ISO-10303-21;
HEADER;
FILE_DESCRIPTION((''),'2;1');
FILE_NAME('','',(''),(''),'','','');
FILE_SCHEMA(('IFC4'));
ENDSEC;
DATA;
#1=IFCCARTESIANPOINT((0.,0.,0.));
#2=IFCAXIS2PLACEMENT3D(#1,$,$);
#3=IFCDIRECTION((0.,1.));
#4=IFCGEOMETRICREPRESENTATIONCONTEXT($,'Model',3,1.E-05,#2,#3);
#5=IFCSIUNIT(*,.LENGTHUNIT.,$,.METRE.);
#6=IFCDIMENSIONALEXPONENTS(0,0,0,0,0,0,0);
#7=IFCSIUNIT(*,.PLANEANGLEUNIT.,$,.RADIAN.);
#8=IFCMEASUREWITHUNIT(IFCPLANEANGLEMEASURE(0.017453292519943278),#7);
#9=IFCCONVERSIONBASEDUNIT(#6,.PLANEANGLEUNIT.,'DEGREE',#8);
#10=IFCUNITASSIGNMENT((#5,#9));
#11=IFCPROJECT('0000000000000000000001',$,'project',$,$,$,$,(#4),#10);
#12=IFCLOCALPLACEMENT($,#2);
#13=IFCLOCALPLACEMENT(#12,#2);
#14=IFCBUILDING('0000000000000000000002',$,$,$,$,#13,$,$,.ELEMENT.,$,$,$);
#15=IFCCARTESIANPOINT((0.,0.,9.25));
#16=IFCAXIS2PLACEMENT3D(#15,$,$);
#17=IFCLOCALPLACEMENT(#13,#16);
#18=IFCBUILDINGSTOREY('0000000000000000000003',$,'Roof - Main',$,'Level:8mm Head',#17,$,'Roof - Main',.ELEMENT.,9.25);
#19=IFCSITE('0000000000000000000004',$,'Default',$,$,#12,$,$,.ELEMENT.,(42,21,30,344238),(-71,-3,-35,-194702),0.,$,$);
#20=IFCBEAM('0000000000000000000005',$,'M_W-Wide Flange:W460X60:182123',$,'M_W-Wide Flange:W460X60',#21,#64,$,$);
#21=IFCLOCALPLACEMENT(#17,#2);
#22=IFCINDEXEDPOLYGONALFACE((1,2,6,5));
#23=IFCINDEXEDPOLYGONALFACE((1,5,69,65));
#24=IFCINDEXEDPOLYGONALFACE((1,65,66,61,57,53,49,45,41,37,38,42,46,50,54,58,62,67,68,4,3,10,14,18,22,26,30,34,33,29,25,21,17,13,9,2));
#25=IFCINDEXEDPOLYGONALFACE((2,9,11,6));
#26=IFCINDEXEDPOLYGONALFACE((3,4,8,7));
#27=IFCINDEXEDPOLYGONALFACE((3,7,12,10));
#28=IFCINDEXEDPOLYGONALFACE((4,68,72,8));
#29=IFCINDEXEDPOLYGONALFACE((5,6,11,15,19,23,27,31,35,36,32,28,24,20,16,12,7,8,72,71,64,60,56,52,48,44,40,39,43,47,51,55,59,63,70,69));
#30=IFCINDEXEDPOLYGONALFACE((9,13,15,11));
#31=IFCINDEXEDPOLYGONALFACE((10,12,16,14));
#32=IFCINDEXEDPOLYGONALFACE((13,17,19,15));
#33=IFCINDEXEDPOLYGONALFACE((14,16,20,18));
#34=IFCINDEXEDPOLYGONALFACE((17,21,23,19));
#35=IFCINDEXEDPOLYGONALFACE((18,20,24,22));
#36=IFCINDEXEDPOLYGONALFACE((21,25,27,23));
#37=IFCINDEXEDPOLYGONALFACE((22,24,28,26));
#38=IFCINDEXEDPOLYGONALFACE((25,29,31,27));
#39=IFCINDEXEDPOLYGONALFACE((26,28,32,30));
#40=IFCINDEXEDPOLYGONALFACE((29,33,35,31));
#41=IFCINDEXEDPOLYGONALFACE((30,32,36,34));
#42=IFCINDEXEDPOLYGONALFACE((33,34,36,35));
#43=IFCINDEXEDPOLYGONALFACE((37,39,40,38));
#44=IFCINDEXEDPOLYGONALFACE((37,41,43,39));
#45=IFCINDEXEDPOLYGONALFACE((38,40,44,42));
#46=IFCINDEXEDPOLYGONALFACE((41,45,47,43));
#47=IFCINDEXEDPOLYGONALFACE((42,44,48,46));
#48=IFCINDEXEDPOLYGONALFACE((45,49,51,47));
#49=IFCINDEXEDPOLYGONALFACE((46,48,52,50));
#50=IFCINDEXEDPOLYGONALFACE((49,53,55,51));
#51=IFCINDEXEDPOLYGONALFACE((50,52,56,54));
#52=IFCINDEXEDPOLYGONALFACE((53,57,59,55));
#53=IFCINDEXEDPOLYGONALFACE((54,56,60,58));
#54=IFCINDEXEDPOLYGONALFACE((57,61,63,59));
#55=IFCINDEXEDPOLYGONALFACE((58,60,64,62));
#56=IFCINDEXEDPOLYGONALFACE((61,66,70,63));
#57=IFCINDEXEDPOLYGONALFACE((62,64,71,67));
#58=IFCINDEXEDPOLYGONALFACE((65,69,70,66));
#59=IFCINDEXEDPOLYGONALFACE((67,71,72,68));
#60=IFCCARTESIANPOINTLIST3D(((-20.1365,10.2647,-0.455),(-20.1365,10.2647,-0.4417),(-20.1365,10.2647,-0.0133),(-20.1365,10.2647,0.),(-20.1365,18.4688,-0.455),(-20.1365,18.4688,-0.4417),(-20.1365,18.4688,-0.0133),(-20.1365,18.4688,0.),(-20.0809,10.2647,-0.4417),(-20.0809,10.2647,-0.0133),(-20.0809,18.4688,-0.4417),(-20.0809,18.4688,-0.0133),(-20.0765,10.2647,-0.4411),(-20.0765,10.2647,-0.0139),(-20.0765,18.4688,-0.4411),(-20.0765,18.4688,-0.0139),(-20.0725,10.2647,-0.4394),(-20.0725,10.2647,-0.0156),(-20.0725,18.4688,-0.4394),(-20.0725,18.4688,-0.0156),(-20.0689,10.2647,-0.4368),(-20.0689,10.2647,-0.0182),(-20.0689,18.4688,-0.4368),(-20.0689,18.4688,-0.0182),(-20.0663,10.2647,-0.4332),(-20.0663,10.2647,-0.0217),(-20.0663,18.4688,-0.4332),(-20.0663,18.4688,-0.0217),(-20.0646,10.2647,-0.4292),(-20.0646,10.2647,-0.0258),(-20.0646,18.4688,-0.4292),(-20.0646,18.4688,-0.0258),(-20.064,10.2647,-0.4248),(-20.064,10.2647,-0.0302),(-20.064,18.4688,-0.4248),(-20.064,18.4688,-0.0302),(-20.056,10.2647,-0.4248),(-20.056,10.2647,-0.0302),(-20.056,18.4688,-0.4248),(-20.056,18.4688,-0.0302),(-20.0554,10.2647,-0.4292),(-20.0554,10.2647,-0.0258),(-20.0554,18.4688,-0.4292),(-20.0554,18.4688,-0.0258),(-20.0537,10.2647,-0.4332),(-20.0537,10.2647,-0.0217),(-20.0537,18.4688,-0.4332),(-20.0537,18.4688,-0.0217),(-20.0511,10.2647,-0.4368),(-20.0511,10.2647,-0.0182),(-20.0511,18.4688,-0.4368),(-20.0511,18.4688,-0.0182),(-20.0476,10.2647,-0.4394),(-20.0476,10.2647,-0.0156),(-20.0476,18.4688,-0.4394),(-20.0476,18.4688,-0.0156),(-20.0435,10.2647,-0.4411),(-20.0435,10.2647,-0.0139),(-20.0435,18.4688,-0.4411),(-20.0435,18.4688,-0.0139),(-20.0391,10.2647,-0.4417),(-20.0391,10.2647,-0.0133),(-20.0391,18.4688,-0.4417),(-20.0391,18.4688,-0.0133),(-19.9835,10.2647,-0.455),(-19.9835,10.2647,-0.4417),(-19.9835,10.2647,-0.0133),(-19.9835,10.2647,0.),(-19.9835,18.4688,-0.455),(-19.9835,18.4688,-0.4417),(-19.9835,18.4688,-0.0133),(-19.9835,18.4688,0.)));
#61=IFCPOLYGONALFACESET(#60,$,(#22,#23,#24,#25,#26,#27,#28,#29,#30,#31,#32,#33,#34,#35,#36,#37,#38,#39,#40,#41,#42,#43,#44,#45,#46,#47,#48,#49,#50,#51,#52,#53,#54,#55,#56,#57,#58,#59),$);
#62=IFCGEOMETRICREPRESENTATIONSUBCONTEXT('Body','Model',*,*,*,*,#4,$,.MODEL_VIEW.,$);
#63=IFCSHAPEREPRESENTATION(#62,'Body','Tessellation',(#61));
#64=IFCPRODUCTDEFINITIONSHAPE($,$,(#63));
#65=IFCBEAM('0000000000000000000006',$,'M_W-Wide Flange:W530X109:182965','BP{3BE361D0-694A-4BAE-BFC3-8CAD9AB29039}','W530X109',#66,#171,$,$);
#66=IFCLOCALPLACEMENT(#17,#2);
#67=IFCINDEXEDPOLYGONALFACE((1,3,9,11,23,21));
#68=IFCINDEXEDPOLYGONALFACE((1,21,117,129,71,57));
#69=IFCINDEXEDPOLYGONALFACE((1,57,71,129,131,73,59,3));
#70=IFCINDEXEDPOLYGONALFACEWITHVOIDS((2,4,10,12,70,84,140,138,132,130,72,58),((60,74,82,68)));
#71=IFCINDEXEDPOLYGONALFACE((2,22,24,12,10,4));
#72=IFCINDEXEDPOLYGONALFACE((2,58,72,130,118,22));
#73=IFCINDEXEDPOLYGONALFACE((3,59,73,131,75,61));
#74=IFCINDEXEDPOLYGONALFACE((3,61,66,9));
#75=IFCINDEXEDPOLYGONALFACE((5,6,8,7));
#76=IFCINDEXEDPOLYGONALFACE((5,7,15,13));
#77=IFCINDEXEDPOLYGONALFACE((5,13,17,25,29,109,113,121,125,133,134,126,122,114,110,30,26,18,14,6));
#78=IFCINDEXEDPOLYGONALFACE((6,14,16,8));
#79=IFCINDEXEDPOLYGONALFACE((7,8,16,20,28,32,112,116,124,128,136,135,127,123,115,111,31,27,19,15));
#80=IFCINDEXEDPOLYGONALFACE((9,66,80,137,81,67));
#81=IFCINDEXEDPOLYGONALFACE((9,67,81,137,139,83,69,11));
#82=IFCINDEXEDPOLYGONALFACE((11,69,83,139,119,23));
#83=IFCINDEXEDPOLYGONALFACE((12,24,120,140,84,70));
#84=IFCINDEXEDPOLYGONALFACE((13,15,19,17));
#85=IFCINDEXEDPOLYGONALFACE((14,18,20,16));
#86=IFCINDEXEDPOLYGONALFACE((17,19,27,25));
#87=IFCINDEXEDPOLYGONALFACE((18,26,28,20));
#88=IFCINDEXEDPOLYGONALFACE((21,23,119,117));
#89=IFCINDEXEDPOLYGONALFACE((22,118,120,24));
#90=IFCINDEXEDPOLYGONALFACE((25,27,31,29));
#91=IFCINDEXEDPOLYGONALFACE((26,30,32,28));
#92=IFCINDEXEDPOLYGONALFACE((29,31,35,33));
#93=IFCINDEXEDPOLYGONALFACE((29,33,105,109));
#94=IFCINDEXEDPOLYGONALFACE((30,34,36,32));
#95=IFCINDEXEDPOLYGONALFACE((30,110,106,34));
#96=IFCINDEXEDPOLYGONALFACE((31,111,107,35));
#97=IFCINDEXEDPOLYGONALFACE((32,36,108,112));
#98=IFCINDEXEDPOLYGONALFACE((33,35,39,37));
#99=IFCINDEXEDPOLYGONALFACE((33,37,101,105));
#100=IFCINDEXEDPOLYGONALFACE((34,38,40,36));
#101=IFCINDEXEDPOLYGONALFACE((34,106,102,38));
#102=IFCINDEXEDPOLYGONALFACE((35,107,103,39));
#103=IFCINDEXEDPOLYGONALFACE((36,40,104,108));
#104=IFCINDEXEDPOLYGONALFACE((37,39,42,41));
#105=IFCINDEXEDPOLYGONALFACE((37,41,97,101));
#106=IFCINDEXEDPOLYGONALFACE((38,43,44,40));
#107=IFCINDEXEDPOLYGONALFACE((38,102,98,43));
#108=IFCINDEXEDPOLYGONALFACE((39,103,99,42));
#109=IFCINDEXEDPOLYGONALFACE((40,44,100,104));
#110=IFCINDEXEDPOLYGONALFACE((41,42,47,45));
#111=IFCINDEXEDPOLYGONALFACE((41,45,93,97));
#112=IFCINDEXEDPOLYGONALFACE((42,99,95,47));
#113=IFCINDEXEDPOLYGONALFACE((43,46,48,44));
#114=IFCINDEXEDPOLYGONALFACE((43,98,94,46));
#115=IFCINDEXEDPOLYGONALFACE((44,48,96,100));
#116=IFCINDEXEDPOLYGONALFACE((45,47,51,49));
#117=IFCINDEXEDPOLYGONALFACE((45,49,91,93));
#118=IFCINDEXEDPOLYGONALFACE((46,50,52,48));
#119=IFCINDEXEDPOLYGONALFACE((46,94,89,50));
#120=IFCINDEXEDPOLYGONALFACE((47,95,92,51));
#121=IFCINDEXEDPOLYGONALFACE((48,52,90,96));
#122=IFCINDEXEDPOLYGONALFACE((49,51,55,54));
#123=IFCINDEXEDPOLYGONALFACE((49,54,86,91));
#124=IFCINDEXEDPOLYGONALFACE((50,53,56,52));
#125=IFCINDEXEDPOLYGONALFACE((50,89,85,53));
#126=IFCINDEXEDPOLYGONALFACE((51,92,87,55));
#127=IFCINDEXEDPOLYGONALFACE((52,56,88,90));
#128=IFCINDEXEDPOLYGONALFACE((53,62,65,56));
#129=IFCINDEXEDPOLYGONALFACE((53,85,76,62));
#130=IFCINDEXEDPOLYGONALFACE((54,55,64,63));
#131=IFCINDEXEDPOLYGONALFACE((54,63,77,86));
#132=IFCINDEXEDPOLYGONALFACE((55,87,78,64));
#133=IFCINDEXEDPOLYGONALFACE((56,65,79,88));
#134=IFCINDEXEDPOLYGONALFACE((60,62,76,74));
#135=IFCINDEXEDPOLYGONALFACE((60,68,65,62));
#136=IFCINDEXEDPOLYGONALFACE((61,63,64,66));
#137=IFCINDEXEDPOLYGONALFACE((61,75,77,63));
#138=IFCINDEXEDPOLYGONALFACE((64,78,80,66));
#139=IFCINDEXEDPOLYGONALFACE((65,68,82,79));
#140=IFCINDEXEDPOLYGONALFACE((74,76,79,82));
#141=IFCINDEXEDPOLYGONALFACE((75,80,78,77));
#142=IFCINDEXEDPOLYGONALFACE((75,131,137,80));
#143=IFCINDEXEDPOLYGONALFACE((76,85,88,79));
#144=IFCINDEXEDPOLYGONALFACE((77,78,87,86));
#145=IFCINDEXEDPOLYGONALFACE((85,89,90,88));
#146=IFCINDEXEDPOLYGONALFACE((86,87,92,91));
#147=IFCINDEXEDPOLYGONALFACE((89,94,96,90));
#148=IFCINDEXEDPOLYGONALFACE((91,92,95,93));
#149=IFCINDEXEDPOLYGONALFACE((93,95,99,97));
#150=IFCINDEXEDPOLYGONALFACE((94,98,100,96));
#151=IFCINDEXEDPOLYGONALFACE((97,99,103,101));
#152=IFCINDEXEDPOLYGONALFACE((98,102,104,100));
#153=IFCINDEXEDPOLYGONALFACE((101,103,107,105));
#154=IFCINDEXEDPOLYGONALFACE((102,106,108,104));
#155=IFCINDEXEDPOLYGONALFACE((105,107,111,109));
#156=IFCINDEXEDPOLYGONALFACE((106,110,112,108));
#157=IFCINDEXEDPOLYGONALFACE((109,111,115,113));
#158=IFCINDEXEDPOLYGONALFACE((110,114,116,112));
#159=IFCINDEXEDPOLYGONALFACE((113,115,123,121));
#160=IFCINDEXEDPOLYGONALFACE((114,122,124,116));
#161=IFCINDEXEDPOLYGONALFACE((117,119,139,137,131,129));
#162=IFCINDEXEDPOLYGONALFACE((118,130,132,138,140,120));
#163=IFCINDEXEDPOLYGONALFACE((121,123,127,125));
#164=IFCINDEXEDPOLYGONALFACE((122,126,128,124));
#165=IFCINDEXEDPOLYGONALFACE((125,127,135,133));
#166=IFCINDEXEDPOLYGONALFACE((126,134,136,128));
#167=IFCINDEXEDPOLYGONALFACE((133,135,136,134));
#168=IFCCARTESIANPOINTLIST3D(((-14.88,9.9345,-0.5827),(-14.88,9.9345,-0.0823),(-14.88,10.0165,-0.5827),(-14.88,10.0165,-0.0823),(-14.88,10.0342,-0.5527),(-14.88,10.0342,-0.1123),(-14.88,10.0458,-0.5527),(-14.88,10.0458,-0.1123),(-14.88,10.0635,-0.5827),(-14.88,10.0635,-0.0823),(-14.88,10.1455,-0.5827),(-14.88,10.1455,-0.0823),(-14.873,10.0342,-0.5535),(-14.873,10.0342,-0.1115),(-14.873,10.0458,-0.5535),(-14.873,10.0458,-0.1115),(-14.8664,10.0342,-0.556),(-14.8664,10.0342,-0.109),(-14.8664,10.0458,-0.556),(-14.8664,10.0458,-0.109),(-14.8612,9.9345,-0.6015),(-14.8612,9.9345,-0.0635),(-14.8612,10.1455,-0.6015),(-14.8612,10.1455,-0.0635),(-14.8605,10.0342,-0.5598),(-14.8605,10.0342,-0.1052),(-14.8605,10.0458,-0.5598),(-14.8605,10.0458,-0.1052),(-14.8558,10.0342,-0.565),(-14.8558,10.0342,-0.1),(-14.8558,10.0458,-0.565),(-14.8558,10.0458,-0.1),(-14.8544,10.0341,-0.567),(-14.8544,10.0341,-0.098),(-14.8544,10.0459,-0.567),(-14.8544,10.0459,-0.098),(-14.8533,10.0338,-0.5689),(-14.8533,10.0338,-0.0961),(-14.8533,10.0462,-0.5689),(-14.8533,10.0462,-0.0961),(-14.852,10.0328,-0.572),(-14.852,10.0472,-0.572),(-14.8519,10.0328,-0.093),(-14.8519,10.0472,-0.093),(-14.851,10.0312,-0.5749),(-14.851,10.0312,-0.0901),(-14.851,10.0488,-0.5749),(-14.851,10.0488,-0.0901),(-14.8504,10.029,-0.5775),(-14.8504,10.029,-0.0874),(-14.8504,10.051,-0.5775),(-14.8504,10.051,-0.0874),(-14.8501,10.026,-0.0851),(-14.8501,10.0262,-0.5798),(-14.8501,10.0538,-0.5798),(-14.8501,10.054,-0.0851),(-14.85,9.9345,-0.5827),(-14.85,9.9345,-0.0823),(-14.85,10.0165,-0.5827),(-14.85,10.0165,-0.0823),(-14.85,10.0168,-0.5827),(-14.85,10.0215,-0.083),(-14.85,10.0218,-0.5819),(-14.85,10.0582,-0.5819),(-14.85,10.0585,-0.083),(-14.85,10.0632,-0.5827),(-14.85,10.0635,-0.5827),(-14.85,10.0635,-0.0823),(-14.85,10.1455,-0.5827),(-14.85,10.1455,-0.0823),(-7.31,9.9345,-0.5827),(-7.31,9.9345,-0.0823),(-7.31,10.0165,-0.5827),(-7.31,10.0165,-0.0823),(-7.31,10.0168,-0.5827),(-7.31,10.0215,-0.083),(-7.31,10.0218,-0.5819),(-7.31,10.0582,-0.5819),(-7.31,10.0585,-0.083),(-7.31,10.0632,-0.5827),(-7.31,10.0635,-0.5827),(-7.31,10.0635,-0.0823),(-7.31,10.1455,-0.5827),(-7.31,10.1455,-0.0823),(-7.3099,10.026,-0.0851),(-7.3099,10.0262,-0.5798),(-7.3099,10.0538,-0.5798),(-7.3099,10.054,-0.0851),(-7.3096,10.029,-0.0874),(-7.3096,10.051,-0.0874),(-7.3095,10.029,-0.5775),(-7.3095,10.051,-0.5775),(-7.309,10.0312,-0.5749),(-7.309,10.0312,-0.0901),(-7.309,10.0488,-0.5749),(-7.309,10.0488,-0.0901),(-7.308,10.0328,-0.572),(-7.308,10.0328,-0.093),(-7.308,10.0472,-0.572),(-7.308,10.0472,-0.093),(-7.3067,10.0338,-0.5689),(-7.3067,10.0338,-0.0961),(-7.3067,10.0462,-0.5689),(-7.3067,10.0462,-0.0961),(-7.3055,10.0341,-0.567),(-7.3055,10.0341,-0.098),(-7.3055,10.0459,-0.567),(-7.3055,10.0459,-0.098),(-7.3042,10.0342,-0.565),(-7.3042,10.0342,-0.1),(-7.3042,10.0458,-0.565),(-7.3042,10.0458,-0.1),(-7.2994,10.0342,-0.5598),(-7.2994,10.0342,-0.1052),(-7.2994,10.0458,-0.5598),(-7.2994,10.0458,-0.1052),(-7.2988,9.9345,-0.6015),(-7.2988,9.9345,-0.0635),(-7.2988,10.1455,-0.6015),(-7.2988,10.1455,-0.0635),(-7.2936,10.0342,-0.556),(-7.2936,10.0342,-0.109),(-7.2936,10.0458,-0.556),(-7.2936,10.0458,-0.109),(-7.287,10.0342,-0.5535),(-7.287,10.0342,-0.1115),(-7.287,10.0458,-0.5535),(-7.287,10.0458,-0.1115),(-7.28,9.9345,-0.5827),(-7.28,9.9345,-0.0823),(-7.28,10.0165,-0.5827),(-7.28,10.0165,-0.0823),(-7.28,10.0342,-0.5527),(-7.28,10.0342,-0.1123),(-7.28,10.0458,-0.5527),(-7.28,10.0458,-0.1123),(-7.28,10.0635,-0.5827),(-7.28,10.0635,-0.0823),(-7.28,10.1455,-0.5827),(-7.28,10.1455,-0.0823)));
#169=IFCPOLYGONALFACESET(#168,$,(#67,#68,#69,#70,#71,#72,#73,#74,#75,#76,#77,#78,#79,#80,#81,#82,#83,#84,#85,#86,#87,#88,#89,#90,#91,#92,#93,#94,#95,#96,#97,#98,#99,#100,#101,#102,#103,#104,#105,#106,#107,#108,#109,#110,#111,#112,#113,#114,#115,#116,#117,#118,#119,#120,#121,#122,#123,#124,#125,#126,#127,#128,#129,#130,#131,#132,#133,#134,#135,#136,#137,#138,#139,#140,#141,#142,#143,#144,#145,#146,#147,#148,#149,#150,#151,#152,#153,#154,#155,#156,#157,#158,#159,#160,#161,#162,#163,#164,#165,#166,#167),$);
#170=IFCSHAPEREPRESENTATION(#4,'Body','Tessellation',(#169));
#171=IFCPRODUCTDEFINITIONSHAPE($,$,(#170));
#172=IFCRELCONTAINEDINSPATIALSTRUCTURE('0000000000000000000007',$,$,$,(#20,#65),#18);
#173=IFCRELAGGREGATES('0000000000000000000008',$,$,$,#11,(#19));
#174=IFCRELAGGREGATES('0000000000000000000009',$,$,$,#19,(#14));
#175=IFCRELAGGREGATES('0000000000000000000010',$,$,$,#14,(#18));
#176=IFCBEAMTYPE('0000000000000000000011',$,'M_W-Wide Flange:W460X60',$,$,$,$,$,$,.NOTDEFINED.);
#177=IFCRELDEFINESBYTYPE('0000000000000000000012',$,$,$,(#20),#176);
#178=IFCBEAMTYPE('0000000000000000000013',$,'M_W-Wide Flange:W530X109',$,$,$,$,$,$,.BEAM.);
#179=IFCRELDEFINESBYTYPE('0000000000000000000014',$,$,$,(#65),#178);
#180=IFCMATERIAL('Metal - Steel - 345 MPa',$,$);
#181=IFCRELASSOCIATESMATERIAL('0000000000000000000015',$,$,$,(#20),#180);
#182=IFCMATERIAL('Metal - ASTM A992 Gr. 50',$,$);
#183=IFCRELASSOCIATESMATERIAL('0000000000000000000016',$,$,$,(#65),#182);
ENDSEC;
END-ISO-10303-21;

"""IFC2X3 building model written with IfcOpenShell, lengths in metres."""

from ifc_helpers import new_model, entity, si_unit, converted_unit, point, direction, frame, frame_2d, origin, origin_2d, place, context, subcontext, project, spatial, polyline, circle_curve, line_curve, trimmed, segment, composite_curve, i_section, outline, extrude, material, type_object, element, save


model = new_model("IFC2X3")

# Units and contexts
model_context = context("Model", 3, precision=1e-05, world=origin(), true_north=direction((0.0, 1.0)))
body_context = subcontext(model_context, "Body", "Model", "MODEL_VIEW")
ifc_project = project(units=[si_unit("LENGTHUNIT", "METRE"), converted_unit("PLANEANGLEUNIT", "DEGREE", entity("IfcPlaneAngleMeasure", 0.017453292519943278), si_unit("PLANEANGLEUNIT", "RADIAN"), dimensions=[0, 0, 0, 0, 0, 0, 0])], contexts=[model_context])

# Site, building, storey
site_placement = place(None, origin())
site = spatial("IfcSite", under=ifc_project, at=site_placement, Name="Default", CompositionType="ELEMENT", RefLatitude=(42, 21, 30, 344238), RefLongitude=(-71, -3, -35, -194702), RefElevation=0.0)
building_placement = place(site_placement, origin())
building = spatial("IfcBuilding", under=site, at=building_placement, CompositionType="ELEMENT")
storey_placement = place(building_placement, frame((0.0, 0.0, 9.25)))
storey = spatial("IfcBuildingStorey", under=building, at=storey_placement, Name="Roof - Main", ObjectType="Level:8mm Head", LongName="Roof - Main", CompositionType="ELEMENT", Elevation=9.25)

# Beam
ifc_material_1 = material(Name="Metal - Steel - 345 MPa")
beam_type_1 = type_object("IfcBeamType", Name="M_W-Wide Flange:W460X60", PredefinedType="NOTDEFINED")
beam_1_placement = place(storey_placement, frame((-20.06, 10.04, 0.0), z_axis=(0.0, 0.0, 1.0), x_axis=(0.0, 1.0, 0.0)))
element("IfcBeam", 1, at=beam_1_placement, inside=storey, type_object=beam_type_1, material=ifc_material_1, Name="M_W-Wide Flange:W460X60:182123", ObjectType="M_W-Wide Flange:W460X60", context=body_context, shape_type="SweptSolid", body=[
    extrude(i_section(OverallWidth=0.153, OverallDepth=0.455, WebThickness=0.008, FlangeThickness=0.0133, FilletRadius=0.0169, at=frame_2d((0.0, 0.0), x_axis=(0.0, 1.0))), frame((0.2247, 0.0, -0.2275), z_axis=(1.0, 0.0, 0.0), x_axis=(0.0, 0.0, -1.0)), (0.0, 0.0, 1.0), 8.2041),
])

# Beam, openings
ifc_material_2 = material(Name="Metal - ASTM A992 Gr. 50")
beam_type_2 = type_object("IfcBeamType", Name="M_W-Wide Flange:W530X109", PredefinedType="BEAM")
beam_2_placement = place(storey_placement, frame((-14.88, 10.04, -0.3325), z_axis=(-1.0, 0.0, 0.0), x_axis=(0.0, -1.0, 0.0)))
beam_2 = element("IfcBeam", 2, at=beam_2_placement, inside=storey, type_object=beam_type_2, material=ifc_material_2, Name="M_W-Wide Flange:W530X109:182965", Description="BP{3BE361D0-694A-4BAE-BFC3-8CAD9AB29039}", ObjectType="W530X109", context=model_context, shape_type="SweptSolid", body=[
    extrude(i_section(OverallWidth=0.211, OverallDepth=0.538, WebThickness=0.0116, FlangeThickness=0.0188, FilletRadius=0.0177, at=origin_2d()), origin(), (0.0, 0.0, -1.0), 7.6),
])
opening_1_placement = place(beam_2_placement, frame((0.2056, 0.269, 0.0), z_axis=(-1.0, 0.0, 0.0), x_axis=(0.0, 0.0, 1.0)))
element("IfcOpeningElement", 3, at=opening_1_placement, cuts=beam_2, ObjectType="Opening", context=model_context, shape_type="SweptSolid", body=[
    extrude(outline(polyline([(0.0, -0.0188), (0.0, 0.0), (-0.0188, 0.0), (0.0, -0.0188)])), origin(), (0.0, 0.0, 1.0), 0.4112),
])
opening_2_placement = place(beam_2_placement, frame((-0.2056, 0.269, 0.0), z_axis=(1.0, 0.0, 0.0), x_axis=(0.0, 0.0, -1.0)))
element("IfcOpeningElement", 4, at=opening_2_placement, cuts=beam_2, ObjectType="Opening", context=model_context, shape_type="SweptSolid", body=[
    extrude(outline(polyline([(0.0, -0.5192), (0.0, -0.538), (0.0188, -0.538), (0.0, -0.5192)])), origin(), (0.0, 0.0, 1.0), 0.4112),
])
opening_3_placement = place(beam_2_placement, frame((0.2056, 0.269, 0.0), z_axis=(-1.0, 0.0, 0.0), x_axis=(0.0, 0.0, 1.0)))
element("IfcOpeningElement", 5, at=opening_3_placement, cuts=beam_2, ObjectType="Opening", context=model_context, shape_type="SweptSolid", body=[
    extrude(outline(composite_curve([segment(trimmed(circle_curve(frame_2d((0.0, -0.0188), x_axis=(1.0, 0.0)), 0.03), [point((-0.03, -0.0188))], [point((0.03, -0.0188))], True, "CARTESIAN"), True, "CONTINUOUS"), segment(trimmed(line_curve((0.03, -0.0188), (-1.0, 0.0), 0.06), [point((0.03, -0.0188))], [point((-0.03, -0.0188))], True, "CARTESIAN"), True, "CONTINUOUS")], self_intersect="UNKNOWN")), origin(), (0.0, 0.0, 1.0), 0.4112),
])
opening_4_placement = place(beam_2_placement, frame((-0.2056, 0.269, 0.0), z_axis=(1.0, 0.0, 0.0), x_axis=(0.0, 0.0, -1.0)))
element("IfcOpeningElement", 6, at=opening_4_placement, cuts=beam_2, ObjectType="Opening", context=model_context, shape_type="SweptSolid", body=[
    extrude(outline(composite_curve([segment(trimmed(circle_curve(frame_2d((0.0, -0.5192), x_axis=(1.0, 0.0)), 0.03), [point((0.03, -0.5192))], [point((-0.03, -0.5192))], True, "CARTESIAN"), True, "CONTINUOUS"), segment(trimmed(line_curve((-0.03, -0.5192), (1.0, 0.0), 0.06), [point((-0.03, -0.5192))], [point((0.03, -0.5192))], True, "CARTESIAN"), True, "CONTINUOUS")], self_intersect="UNKNOWN")), origin(), (0.0, 0.0, 1.0), 0.4112),
])
opening_5_placement = place(beam_2_placement, frame((-0.2056, 0.269, -7.6), z_axis=(1.0, 0.0, 0.0), x_axis=(0.0, 0.0, -1.0)))
element("IfcOpeningElement", 7, at=opening_5_placement, cuts=beam_2, ObjectType="Opening", context=model_context, shape_type="SweptSolid", body=[
    extrude(outline(polyline([(0.0, -0.0188), (0.0, 0.0), (-0.0188, 0.0), (0.0, -0.0188)])), origin(), (0.0, 0.0, 1.0), 0.4112),
])
opening_6_placement = place(beam_2_placement, frame((0.2056, 0.269, -7.6), z_axis=(-1.0, 0.0, 0.0), x_axis=(0.0, 0.0, 1.0)))
element("IfcOpeningElement", 8, at=opening_6_placement, cuts=beam_2, ObjectType="Opening", context=model_context, shape_type="SweptSolid", body=[
    extrude(outline(polyline([(0.0, -0.5192), (0.0, -0.538), (0.0188, -0.538), (0.0, -0.5192)])), origin(), (0.0, 0.0, 1.0), 0.4112),
])
opening_7_placement = place(beam_2_placement, frame((-0.2056, 0.269, -7.6), z_axis=(1.0, 0.0, 0.0), x_axis=(0.0, 0.0, -1.0)))
element("IfcOpeningElement", 9, at=opening_7_placement, cuts=beam_2, ObjectType="Opening", context=model_context, shape_type="SweptSolid", body=[
    extrude(outline(composite_curve([segment(trimmed(circle_curve(frame_2d((0.0, -0.0188), x_axis=(1.0, 0.0)), 0.03), [point((-0.03, -0.0188))], [point((0.03, -0.0188))], True, "CARTESIAN"), True, "CONTINUOUS"), segment(trimmed(line_curve((0.03, -0.0188), (-1.0, 0.0), 0.06), [point((0.03, -0.0188))], [point((-0.03, -0.0188))], True, "CARTESIAN"), True, "CONTINUOUS")], self_intersect="UNKNOWN")), origin(), (0.0, 0.0, 1.0), 0.4112),
])
opening_8_placement = place(beam_2_placement, frame((0.2056, 0.269, -7.6), z_axis=(-1.0, 0.0, 0.0), x_axis=(0.0, 0.0, 1.0)))
element("IfcOpeningElement", 10, at=opening_8_placement, cuts=beam_2, ObjectType="Opening", context=model_context, shape_type="SweptSolid", body=[
    extrude(outline(composite_curve([segment(trimmed(circle_curve(frame_2d((0.0, -0.5192), x_axis=(1.0, 0.0)), 0.03), [point((0.03, -0.5192))], [point((-0.03, -0.5192))], True, "CARTESIAN"), True, "CONTINUOUS"), segment(trimmed(line_curve((-0.03, -0.5192), (1.0, 0.0), 0.06), [point((-0.03, -0.5192))], [point((0.03, -0.5192))], True, "CARTESIAN"), True, "CONTINUOUS")], self_intersect="UNKNOWN")), origin(), (0.0, 0.0, 1.0), 0.4112),
])

save(model, "model.ifc")
